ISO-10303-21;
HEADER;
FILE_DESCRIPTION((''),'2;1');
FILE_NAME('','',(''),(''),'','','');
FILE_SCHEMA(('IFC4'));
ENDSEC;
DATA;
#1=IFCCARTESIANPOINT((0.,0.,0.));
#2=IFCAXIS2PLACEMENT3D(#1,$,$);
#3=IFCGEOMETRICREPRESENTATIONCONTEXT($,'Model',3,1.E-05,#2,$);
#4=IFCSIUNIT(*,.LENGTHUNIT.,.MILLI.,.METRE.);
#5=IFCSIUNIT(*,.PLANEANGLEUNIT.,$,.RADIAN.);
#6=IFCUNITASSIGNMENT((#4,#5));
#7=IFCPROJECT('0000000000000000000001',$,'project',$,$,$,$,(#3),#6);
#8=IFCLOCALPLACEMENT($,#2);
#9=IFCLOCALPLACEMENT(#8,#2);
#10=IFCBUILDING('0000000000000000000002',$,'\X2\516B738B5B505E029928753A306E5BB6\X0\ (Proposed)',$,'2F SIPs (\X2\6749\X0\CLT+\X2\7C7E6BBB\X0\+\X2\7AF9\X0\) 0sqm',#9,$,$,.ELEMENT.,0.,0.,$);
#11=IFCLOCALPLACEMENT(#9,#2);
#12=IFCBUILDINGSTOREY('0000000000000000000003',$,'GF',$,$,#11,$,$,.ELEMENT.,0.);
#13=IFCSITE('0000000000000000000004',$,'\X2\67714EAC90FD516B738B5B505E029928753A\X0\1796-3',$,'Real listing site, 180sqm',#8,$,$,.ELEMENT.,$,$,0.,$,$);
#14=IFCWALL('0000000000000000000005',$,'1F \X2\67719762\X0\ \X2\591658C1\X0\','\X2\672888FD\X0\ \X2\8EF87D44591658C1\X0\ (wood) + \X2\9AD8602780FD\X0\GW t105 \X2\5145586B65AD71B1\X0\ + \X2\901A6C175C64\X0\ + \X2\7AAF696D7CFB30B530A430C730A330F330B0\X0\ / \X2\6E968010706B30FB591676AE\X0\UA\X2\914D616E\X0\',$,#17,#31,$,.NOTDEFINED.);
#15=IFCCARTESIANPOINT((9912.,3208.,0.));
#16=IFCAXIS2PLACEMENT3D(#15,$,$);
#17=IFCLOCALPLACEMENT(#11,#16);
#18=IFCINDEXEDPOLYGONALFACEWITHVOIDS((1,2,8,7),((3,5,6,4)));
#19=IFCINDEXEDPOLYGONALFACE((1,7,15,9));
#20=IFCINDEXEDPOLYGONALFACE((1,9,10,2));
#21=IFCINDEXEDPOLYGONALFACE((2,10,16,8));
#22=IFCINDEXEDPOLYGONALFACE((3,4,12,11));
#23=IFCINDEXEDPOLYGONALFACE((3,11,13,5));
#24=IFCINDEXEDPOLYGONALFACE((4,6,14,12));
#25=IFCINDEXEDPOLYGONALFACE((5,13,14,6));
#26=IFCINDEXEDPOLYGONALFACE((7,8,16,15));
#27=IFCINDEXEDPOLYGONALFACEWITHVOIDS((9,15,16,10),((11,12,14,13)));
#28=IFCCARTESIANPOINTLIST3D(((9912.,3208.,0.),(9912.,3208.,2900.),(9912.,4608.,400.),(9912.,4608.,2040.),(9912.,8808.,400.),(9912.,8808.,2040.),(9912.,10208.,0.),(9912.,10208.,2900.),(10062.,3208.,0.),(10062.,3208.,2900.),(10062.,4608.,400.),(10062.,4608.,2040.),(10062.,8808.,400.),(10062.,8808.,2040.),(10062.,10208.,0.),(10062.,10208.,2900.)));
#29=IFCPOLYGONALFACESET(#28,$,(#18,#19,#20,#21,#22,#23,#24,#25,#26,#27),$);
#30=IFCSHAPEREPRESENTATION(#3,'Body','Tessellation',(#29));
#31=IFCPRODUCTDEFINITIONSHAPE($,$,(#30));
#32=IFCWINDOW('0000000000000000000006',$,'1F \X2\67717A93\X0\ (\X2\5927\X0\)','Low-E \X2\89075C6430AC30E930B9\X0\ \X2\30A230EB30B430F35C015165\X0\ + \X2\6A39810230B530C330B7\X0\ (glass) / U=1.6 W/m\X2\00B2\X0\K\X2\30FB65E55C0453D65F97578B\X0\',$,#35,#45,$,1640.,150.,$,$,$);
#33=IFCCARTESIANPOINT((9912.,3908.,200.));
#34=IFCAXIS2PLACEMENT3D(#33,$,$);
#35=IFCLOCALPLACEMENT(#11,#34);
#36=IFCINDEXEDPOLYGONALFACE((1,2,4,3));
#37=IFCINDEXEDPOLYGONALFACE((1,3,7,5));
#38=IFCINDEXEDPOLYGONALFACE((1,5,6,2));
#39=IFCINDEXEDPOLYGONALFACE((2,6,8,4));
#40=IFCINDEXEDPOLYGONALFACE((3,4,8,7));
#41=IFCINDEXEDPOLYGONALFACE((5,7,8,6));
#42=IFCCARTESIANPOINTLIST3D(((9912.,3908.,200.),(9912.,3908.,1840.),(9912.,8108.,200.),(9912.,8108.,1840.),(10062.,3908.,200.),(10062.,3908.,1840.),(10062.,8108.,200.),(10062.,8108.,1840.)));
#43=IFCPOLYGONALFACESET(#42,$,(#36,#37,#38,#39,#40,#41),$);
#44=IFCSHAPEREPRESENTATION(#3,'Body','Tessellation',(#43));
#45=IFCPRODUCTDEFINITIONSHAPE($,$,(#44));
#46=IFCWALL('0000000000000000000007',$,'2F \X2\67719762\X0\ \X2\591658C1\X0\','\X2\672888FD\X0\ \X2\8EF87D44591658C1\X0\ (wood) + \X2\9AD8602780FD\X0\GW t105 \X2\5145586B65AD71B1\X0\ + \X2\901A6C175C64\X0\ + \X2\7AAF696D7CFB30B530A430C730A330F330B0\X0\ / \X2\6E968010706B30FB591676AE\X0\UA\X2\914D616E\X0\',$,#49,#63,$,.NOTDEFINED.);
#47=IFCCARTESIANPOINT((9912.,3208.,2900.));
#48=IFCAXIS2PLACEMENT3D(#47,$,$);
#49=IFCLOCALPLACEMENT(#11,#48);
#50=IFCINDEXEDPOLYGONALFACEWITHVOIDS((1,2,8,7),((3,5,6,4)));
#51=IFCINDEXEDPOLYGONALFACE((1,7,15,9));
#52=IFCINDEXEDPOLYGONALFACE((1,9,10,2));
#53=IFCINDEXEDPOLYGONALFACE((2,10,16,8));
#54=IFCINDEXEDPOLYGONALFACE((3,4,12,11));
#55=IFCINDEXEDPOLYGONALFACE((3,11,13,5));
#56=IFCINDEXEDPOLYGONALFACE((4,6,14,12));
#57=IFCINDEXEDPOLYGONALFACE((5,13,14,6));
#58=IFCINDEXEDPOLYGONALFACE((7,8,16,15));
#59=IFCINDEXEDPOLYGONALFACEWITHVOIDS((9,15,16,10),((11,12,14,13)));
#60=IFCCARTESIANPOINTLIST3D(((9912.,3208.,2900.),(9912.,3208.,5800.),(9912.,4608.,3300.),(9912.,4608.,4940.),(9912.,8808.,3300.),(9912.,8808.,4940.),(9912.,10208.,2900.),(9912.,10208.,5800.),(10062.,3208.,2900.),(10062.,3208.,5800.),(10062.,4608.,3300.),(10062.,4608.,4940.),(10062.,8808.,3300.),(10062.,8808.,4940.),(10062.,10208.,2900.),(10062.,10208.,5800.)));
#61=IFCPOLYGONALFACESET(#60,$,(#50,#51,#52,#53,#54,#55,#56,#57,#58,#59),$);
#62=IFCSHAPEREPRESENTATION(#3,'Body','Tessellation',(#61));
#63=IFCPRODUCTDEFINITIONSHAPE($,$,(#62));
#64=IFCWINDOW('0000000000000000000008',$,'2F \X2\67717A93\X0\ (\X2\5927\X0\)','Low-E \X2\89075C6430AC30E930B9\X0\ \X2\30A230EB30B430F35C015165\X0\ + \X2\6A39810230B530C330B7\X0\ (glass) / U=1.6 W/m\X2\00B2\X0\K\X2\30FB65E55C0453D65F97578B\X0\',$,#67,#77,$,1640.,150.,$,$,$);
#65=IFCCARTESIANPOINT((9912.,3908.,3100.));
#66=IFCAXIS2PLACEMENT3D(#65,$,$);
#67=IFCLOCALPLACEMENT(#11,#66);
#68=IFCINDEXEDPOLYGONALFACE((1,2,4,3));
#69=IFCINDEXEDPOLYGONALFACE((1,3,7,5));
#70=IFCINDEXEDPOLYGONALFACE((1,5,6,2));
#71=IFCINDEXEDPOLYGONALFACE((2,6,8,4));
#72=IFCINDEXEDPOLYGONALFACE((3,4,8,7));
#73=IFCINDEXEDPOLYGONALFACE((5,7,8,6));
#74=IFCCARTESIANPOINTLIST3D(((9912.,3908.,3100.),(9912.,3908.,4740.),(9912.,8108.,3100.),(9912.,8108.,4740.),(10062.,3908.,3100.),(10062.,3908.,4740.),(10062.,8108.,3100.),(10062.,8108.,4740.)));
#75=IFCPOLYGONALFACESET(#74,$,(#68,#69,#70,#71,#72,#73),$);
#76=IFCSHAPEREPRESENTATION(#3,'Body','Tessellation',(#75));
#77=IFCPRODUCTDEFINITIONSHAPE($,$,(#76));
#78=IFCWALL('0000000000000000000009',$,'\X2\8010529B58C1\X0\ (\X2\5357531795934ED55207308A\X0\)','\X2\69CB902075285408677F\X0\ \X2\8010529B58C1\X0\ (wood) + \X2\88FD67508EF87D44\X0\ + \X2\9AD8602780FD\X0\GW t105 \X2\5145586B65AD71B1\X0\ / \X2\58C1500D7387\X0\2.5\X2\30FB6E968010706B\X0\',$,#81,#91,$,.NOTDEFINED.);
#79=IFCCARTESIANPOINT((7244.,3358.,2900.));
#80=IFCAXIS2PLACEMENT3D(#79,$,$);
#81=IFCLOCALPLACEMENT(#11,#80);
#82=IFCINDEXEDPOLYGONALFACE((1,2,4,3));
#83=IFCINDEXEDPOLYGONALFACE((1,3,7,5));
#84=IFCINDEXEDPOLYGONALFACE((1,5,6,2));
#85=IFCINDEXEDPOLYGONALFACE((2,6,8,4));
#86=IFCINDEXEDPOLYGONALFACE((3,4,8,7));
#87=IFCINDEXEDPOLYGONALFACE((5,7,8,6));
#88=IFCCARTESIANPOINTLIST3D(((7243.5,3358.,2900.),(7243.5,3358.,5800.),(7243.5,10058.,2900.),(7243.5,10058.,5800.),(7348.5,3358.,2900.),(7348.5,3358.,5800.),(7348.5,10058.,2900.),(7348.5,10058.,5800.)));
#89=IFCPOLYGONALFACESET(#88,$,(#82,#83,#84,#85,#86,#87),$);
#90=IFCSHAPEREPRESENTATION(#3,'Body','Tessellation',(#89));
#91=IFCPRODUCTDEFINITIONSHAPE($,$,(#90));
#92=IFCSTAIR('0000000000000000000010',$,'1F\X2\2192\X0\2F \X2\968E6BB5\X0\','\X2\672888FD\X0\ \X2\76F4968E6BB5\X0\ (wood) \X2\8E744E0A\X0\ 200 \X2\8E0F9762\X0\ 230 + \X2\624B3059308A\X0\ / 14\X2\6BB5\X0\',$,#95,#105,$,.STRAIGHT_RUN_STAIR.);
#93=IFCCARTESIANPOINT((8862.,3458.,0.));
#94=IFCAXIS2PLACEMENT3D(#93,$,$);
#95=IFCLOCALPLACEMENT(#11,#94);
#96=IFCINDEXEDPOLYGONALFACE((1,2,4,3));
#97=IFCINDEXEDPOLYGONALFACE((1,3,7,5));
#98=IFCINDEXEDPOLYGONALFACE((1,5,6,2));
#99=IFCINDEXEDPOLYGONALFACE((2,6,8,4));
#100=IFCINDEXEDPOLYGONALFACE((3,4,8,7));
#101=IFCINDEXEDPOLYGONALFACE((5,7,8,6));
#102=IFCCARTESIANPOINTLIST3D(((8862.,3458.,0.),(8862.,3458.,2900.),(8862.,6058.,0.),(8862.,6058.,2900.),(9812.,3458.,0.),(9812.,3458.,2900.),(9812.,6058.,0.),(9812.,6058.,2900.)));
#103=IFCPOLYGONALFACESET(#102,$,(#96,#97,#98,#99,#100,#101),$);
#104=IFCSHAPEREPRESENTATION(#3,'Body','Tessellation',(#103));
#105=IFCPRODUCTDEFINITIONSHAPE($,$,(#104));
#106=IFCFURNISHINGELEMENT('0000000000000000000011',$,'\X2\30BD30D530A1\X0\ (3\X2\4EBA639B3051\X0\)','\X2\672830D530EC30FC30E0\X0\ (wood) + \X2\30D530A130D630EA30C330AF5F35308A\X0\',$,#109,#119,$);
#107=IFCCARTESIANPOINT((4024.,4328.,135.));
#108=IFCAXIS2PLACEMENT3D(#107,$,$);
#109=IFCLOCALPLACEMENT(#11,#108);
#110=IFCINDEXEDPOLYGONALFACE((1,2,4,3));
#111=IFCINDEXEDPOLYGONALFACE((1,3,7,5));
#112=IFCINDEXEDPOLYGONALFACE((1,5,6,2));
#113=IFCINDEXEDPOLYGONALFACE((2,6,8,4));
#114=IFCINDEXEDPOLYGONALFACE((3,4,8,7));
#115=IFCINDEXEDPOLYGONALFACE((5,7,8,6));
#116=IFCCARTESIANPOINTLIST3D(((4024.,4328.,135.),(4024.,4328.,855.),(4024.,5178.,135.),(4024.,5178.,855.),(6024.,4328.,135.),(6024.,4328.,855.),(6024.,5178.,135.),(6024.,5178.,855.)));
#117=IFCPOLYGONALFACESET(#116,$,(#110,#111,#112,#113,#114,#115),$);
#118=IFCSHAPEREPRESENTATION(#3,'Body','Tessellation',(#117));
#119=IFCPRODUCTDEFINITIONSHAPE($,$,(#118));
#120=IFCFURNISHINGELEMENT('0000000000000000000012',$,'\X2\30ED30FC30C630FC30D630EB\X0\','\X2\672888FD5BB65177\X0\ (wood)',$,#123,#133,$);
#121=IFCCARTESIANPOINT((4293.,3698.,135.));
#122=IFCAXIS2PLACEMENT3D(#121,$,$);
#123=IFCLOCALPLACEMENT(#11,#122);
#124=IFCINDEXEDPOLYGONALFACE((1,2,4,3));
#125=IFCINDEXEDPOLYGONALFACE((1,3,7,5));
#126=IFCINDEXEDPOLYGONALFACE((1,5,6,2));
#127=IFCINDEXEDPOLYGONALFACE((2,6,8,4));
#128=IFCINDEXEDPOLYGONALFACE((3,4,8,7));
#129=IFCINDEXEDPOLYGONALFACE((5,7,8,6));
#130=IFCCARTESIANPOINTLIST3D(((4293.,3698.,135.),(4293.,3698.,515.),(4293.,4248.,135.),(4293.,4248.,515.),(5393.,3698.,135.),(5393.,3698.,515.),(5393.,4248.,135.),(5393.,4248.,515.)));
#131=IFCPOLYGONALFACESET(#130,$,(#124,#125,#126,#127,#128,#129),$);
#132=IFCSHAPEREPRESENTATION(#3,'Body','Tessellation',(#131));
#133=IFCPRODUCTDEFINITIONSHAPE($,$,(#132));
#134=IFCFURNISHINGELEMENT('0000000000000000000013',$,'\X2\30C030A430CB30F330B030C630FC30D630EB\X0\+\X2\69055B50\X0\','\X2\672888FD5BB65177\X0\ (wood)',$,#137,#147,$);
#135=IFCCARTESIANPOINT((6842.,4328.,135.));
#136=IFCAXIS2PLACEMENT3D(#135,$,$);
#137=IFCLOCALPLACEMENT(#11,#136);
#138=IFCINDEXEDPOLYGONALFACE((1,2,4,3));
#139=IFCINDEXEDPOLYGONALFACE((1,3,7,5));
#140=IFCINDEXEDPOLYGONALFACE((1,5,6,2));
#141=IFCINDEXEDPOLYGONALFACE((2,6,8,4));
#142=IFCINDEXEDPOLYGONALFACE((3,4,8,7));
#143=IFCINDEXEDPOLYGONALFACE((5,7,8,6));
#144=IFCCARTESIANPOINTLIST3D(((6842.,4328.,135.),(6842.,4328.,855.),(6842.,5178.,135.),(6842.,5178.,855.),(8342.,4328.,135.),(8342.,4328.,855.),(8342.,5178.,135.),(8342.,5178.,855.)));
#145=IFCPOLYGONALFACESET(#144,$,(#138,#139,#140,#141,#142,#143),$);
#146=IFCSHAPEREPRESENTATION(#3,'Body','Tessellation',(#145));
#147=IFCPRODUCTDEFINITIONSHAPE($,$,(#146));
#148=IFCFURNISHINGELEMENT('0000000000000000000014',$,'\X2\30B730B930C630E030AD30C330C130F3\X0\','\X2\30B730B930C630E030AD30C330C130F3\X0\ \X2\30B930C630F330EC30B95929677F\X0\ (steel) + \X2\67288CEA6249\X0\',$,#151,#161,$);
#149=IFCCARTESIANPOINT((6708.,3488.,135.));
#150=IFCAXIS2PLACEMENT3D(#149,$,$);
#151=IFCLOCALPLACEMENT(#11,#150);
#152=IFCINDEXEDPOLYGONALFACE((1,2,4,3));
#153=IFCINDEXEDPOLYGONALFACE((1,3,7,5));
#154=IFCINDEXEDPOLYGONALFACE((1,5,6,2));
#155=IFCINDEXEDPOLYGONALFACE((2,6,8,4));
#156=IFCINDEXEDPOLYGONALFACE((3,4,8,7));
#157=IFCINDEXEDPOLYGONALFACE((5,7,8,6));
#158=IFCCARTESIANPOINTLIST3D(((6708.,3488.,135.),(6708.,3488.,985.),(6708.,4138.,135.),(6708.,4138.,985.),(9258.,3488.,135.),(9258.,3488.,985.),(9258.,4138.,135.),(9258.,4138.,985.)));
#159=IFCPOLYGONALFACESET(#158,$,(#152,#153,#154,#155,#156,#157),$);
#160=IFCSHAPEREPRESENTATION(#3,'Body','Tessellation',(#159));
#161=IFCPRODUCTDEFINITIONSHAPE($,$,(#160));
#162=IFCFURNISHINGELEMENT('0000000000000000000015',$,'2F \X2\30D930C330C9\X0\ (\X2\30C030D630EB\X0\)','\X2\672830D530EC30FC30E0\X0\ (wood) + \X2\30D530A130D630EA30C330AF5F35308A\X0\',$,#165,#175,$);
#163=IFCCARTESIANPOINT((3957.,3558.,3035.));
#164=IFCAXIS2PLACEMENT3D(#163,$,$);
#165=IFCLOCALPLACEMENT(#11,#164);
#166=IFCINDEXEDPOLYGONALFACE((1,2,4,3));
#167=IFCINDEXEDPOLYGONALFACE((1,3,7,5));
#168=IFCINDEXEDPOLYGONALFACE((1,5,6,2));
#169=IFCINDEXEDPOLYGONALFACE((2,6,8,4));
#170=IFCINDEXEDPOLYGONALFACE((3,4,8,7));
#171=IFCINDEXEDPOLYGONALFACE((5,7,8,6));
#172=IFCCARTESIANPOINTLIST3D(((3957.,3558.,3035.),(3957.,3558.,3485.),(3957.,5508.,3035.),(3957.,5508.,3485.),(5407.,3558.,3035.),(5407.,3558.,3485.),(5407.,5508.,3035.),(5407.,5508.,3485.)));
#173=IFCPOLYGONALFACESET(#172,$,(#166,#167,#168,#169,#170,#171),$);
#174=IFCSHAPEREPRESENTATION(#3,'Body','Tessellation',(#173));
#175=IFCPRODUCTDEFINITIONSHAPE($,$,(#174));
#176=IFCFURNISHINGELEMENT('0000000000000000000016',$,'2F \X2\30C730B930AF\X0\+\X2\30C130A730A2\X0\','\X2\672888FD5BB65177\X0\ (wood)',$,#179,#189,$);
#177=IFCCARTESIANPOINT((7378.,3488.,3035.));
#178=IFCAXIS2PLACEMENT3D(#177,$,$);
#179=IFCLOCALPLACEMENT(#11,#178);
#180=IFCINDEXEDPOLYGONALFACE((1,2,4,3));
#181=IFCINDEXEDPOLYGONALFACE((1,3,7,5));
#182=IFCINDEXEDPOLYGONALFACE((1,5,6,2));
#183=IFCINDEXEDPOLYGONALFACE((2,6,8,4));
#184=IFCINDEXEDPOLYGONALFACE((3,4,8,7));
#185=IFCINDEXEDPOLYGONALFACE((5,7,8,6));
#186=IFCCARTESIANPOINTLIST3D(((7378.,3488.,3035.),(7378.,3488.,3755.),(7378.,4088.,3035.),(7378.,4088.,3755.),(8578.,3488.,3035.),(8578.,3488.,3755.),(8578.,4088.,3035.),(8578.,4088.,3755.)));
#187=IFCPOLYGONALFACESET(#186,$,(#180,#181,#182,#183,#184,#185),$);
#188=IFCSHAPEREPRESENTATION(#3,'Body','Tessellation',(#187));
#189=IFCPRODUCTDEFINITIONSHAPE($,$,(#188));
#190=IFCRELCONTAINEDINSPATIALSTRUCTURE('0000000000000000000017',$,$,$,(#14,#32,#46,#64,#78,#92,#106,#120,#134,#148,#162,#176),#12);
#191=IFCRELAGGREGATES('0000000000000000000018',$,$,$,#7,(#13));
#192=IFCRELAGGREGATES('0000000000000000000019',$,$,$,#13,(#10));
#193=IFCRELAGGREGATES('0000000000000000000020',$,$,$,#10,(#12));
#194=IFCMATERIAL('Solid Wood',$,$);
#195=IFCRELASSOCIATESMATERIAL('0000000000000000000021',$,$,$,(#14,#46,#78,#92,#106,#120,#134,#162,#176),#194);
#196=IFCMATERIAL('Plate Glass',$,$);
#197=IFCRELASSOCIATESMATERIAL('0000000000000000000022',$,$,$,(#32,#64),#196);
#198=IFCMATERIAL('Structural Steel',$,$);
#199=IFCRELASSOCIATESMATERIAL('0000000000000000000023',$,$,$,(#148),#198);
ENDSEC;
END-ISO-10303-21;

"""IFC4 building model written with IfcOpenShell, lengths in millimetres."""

from ifc_helpers import new_model, si_unit, frame, frame_2d, origin, place, context, project, spatial, rectangle, extrude, material, element, fill, save


model = new_model("IFC4")

# Units and contexts
model_context = context("Model", 3, precision=1e-05, world=origin())
ifc_project = project(units=[si_unit("LENGTHUNIT", "METRE", prefix="MILLI"), si_unit("PLANEANGLEUNIT", "RADIAN")], contexts=[model_context])

# Site, building, storey
site_placement = place(None, origin())
site = spatial("IfcSite", under=ifc_project, at=site_placement, Name="東京都八王子市館町1796-3", ObjectType="Real listing site, 180sqm", CompositionType="ELEMENT", RefElevation=0.0)
building_placement = place(site_placement, origin())
building = spatial("IfcBuilding", under=site, at=building_placement, Name="八王子市館町の家 (Proposed)", ObjectType="2F SIPs (杉CLT+籾殻+竹) 0sqm", CompositionType="ELEMENT", ElevationOfRefHeight=0.0, ElevationOfTerrain=0.0)
storey_placement = place(building_placement, origin())
storey = spatial("IfcBuildingStorey", under=building, at=storey_placement, Name="GF", CompositionType="ELEMENT", Elevation=0.0)

# Wall, opening, window
ifc_material_1 = material(Name="Solid Wood")
wall_1_placement = place(storey_placement, frame((9912.0, 3208.0, 0.0)))
wall_1 = element("IfcWall", 1, at=wall_1_placement, inside=storey, material=ifc_material_1, Name="1F 東面 外壁", Description="木製 軸組外壁 (wood) + 高性能GW t105 充填断熱 + 通気層 + 窯業系サイディング / 準耐火・外皮UA配慮", PredefinedType="NOTDEFINED", context=model_context, shape_type="SweptSolid", body=[
    extrude(rectangle(XDim=150.0, YDim=7000.0, at=frame_2d((75.0, 3500.0))), frame((9912.0, 3208.0, 0.0)), (0.0, 0.0, 1.0), 2900.0),
])
opening_1_placement = place(storey_placement, frame((9912.0, 3908.0, 200.0)))
opening_1 = element("IfcOpeningElement", 2, at=opening_1_placement, cuts=wall_1, PredefinedType="NOTDEFINED", context=model_context, shape_type="SweptSolid", body=[
    extrude(rectangle(XDim=150.0, YDim=4200.0, at=frame_2d((75.0, 2100.0))), frame((9912.0, 3908.0, 200.0)), (0.0, 0.0, 1.0), 1640.0),
])
ifc_material_2 = material(Name="Plate Glass")
window_1_placement = place(storey_placement, frame((9912.0, 3908.0, 200.0)))
window_1 = element("IfcWindow", 3, at=window_1_placement, inside=storey, material=ifc_material_2, Name="1F 東窓 (大)", Description="Low-E 複層ガラス アルゴン封入 + 樹脂サッシ (glass) / U=1.6 W/m²K・日射取得型", OverallHeight=1640.0, OverallWidth=150.0, context=model_context, shape_type="SweptSolid", body=[
    extrude(rectangle(XDim=150.0, YDim=4200.0, at=frame_2d((75.0, 2100.0))), frame((9912.0, 3908.0, 200.0)), (0.0, 0.0, 1.0), 1640.0),
])
fill(opening_1, window_1)

# Wall, opening, window
wall_2_placement = place(storey_placement, frame((9912.0, 3208.0, 2900.0)))
wall_2 = element("IfcWall", 4, at=wall_2_placement, inside=storey, material=ifc_material_1, Name="2F 東面 外壁", Description="木製 軸組外壁 (wood) + 高性能GW t105 充填断熱 + 通気層 + 窯業系サイディング / 準耐火・外皮UA配慮", PredefinedType="NOTDEFINED", context=model_context, shape_type="SweptSolid", body=[
    extrude(rectangle(XDim=150.0, YDim=7000.0, at=frame_2d((75.0, 3500.0))), frame((9912.0, 3208.0, 2900.0)), (0.0, 0.0, 1.0), 2900.0),
])
opening_2_placement = place(storey_placement, frame((9912.0, 3908.0, 3100.0)))
opening_2 = element("IfcOpeningElement", 5, at=opening_2_placement, cuts=wall_2, PredefinedType="NOTDEFINED", context=model_context, shape_type="SweptSolid", body=[
    extrude(rectangle(XDim=150.0, YDim=4200.0, at=frame_2d((75.0, 2100.0))), frame((9912.0, 3908.0, 3100.0)), (0.0, 0.0, 1.0), 1640.0),
])
window_2_placement = place(storey_placement, frame((9912.0, 3908.0, 3100.0)))
window_2 = element("IfcWindow", 6, at=window_2_placement, inside=storey, material=ifc_material_2, Name="2F 東窓 (大)", Description="Low-E 複層ガラス アルゴン封入 + 樹脂サッシ (glass) / U=1.6 W/m²K・日射取得型", OverallHeight=1640.0, OverallWidth=150.0, context=model_context, shape_type="SweptSolid", body=[
    extrude(rectangle(XDim=150.0, YDim=4200.0, at=frame_2d((75.0, 2100.0))), frame((9912.0, 3908.0, 3100.0)), (0.0, 0.0, 1.0), 1640.0),
])
fill(opening_2, window_2)

# Wall
wall_3_placement = place(storey_placement, frame((7244.0, 3358.0, 2900.0)))
element("IfcWall", 7, at=wall_3_placement, inside=storey, material=ifc_material_1, Name="耐力壁 (南北間仕切り)", Description="構造用合板 耐力壁 (wood) + 製材軸組 + 高性能GW t105 充填断熱 / 壁倍率2.5・準耐火", PredefinedType="NOTDEFINED", context=model_context, shape_type="SweptSolid", body=[
    extrude(rectangle(XDim=105.0, YDim=6700.0, at=frame_2d((52.0, 3350.0))), frame((7244.0, 3358.0, 2900.0)), (0.0, 0.0, 1.0), 2900.0),
])

# Stair
stair_placement = place(storey_placement, frame((8862.0, 3458.0, 0.0)))
element("IfcStair", 8, at=stair_placement, inside=storey, material=ifc_material_1, Name="1F→2F 階段", Description="木製 直階段 (wood) 蹴上 200 踏面 230 + 手すり / 14段", PredefinedType="STRAIGHT_RUN_STAIR", context=model_context, shape_type="SweptSolid", body=[
    extrude(rectangle(XDim=950.0, YDim=2600.0, at=frame_2d((475.0, 1300.0))), frame((8862.0, 3458.0, 0.0)), (0.0, 0.0, 1.0), 2900.0),
])

# Furnishing elements
furnishing_1_placement = place(storey_placement, frame((4024.0, 4328.0, 135.0)))
element("IfcFurnishingElement", 9, at=furnishing_1_placement, inside=storey, material=ifc_material_1, Name="ソファ (3人掛け)", Description="木フレーム (wood) + ファブリック張り", context=model_context, shape_type="SweptSolid", body=[
    extrude(rectangle(XDim=2000.0, YDim=850.0, at=frame_2d((1000.0, 425.0))), frame((4024.0, 4328.0, 135.0)), (0.0, 0.0, 1.0), 720.0),
])
furnishing_2_placement = place(storey_placement, frame((4293.0, 3698.0, 135.0)))
element("IfcFurnishingElement", 10, at=furnishing_2_placement, inside=storey, material=ifc_material_1, Name="ローテーブル", Description="木製家具 (wood)", context=model_context, shape_type="SweptSolid", body=[
    extrude(rectangle(XDim=1100.0, YDim=550.0, at=frame_2d((550.0, 275.0))), frame((4293.0, 3698.0, 135.0)), (0.0, 0.0, 1.0), 380.0),
])
furnishing_3_placement = place(storey_placement, frame((6842.0, 4328.0, 135.0)))
element("IfcFurnishingElement", 11, at=furnishing_3_placement, inside=storey, material=ifc_material_1, Name="ダイニングテーブル+椅子", Description="木製家具 (wood)", context=model_context, shape_type="SweptSolid", body=[
    extrude(rectangle(XDim=1500.0, YDim=850.0, at=frame_2d((750.0, 425.0))), frame((6842.0, 4328.0, 135.0)), (0.0, 0.0, 1.0), 720.0),
])
ifc_material_3 = material(Name="Structural Steel")
furnishing_4_placement = place(storey_placement, frame((6708.0, 3488.0, 135.0)))
element("IfcFurnishingElement", 12, at=furnishing_4_placement, inside=storey, material=ifc_material_3, Name="システムキッチン", Description="システムキッチン ステンレス天板 (steel) + 木質扉", context=model_context, shape_type="SweptSolid", body=[
    extrude(rectangle(XDim=2550.0, YDim=650.0, at=frame_2d((1275.0, 325.0))), frame((6708.0, 3488.0, 135.0)), (0.0, 0.0, 1.0), 850.0),
])
furnishing_5_placement = place(storey_placement, frame((3957.0, 3558.0, 3035.0)))
element("IfcFurnishingElement", 13, at=furnishing_5_placement, inside=storey, material=ifc_material_1, Name="2F ベッド (ダブル)", Description="木フレーム (wood) + ファブリック張り", context=model_context, shape_type="SweptSolid", body=[
    extrude(rectangle(XDim=1450.0, YDim=1950.0, at=frame_2d((725.0, 975.0))), frame((3957.0, 3558.0, 3035.0)), (0.0, 0.0, 1.0), 450.0),
])
furnishing_6_placement = place(storey_placement, frame((7378.0, 3488.0, 3035.0)))
element("IfcFurnishingElement", 14, at=furnishing_6_placement, inside=storey, material=ifc_material_1, Name="2F デスク+チェア", Description="木製家具 (wood)", context=model_context, shape_type="SweptSolid", body=[
    extrude(rectangle(XDim=1200.0, YDim=600.0, at=frame_2d((600.0, 300.0))), frame((7378.0, 3488.0, 3035.0)), (0.0, 0.0, 1.0), 720.0),
])

save(model, "model.ifc")
